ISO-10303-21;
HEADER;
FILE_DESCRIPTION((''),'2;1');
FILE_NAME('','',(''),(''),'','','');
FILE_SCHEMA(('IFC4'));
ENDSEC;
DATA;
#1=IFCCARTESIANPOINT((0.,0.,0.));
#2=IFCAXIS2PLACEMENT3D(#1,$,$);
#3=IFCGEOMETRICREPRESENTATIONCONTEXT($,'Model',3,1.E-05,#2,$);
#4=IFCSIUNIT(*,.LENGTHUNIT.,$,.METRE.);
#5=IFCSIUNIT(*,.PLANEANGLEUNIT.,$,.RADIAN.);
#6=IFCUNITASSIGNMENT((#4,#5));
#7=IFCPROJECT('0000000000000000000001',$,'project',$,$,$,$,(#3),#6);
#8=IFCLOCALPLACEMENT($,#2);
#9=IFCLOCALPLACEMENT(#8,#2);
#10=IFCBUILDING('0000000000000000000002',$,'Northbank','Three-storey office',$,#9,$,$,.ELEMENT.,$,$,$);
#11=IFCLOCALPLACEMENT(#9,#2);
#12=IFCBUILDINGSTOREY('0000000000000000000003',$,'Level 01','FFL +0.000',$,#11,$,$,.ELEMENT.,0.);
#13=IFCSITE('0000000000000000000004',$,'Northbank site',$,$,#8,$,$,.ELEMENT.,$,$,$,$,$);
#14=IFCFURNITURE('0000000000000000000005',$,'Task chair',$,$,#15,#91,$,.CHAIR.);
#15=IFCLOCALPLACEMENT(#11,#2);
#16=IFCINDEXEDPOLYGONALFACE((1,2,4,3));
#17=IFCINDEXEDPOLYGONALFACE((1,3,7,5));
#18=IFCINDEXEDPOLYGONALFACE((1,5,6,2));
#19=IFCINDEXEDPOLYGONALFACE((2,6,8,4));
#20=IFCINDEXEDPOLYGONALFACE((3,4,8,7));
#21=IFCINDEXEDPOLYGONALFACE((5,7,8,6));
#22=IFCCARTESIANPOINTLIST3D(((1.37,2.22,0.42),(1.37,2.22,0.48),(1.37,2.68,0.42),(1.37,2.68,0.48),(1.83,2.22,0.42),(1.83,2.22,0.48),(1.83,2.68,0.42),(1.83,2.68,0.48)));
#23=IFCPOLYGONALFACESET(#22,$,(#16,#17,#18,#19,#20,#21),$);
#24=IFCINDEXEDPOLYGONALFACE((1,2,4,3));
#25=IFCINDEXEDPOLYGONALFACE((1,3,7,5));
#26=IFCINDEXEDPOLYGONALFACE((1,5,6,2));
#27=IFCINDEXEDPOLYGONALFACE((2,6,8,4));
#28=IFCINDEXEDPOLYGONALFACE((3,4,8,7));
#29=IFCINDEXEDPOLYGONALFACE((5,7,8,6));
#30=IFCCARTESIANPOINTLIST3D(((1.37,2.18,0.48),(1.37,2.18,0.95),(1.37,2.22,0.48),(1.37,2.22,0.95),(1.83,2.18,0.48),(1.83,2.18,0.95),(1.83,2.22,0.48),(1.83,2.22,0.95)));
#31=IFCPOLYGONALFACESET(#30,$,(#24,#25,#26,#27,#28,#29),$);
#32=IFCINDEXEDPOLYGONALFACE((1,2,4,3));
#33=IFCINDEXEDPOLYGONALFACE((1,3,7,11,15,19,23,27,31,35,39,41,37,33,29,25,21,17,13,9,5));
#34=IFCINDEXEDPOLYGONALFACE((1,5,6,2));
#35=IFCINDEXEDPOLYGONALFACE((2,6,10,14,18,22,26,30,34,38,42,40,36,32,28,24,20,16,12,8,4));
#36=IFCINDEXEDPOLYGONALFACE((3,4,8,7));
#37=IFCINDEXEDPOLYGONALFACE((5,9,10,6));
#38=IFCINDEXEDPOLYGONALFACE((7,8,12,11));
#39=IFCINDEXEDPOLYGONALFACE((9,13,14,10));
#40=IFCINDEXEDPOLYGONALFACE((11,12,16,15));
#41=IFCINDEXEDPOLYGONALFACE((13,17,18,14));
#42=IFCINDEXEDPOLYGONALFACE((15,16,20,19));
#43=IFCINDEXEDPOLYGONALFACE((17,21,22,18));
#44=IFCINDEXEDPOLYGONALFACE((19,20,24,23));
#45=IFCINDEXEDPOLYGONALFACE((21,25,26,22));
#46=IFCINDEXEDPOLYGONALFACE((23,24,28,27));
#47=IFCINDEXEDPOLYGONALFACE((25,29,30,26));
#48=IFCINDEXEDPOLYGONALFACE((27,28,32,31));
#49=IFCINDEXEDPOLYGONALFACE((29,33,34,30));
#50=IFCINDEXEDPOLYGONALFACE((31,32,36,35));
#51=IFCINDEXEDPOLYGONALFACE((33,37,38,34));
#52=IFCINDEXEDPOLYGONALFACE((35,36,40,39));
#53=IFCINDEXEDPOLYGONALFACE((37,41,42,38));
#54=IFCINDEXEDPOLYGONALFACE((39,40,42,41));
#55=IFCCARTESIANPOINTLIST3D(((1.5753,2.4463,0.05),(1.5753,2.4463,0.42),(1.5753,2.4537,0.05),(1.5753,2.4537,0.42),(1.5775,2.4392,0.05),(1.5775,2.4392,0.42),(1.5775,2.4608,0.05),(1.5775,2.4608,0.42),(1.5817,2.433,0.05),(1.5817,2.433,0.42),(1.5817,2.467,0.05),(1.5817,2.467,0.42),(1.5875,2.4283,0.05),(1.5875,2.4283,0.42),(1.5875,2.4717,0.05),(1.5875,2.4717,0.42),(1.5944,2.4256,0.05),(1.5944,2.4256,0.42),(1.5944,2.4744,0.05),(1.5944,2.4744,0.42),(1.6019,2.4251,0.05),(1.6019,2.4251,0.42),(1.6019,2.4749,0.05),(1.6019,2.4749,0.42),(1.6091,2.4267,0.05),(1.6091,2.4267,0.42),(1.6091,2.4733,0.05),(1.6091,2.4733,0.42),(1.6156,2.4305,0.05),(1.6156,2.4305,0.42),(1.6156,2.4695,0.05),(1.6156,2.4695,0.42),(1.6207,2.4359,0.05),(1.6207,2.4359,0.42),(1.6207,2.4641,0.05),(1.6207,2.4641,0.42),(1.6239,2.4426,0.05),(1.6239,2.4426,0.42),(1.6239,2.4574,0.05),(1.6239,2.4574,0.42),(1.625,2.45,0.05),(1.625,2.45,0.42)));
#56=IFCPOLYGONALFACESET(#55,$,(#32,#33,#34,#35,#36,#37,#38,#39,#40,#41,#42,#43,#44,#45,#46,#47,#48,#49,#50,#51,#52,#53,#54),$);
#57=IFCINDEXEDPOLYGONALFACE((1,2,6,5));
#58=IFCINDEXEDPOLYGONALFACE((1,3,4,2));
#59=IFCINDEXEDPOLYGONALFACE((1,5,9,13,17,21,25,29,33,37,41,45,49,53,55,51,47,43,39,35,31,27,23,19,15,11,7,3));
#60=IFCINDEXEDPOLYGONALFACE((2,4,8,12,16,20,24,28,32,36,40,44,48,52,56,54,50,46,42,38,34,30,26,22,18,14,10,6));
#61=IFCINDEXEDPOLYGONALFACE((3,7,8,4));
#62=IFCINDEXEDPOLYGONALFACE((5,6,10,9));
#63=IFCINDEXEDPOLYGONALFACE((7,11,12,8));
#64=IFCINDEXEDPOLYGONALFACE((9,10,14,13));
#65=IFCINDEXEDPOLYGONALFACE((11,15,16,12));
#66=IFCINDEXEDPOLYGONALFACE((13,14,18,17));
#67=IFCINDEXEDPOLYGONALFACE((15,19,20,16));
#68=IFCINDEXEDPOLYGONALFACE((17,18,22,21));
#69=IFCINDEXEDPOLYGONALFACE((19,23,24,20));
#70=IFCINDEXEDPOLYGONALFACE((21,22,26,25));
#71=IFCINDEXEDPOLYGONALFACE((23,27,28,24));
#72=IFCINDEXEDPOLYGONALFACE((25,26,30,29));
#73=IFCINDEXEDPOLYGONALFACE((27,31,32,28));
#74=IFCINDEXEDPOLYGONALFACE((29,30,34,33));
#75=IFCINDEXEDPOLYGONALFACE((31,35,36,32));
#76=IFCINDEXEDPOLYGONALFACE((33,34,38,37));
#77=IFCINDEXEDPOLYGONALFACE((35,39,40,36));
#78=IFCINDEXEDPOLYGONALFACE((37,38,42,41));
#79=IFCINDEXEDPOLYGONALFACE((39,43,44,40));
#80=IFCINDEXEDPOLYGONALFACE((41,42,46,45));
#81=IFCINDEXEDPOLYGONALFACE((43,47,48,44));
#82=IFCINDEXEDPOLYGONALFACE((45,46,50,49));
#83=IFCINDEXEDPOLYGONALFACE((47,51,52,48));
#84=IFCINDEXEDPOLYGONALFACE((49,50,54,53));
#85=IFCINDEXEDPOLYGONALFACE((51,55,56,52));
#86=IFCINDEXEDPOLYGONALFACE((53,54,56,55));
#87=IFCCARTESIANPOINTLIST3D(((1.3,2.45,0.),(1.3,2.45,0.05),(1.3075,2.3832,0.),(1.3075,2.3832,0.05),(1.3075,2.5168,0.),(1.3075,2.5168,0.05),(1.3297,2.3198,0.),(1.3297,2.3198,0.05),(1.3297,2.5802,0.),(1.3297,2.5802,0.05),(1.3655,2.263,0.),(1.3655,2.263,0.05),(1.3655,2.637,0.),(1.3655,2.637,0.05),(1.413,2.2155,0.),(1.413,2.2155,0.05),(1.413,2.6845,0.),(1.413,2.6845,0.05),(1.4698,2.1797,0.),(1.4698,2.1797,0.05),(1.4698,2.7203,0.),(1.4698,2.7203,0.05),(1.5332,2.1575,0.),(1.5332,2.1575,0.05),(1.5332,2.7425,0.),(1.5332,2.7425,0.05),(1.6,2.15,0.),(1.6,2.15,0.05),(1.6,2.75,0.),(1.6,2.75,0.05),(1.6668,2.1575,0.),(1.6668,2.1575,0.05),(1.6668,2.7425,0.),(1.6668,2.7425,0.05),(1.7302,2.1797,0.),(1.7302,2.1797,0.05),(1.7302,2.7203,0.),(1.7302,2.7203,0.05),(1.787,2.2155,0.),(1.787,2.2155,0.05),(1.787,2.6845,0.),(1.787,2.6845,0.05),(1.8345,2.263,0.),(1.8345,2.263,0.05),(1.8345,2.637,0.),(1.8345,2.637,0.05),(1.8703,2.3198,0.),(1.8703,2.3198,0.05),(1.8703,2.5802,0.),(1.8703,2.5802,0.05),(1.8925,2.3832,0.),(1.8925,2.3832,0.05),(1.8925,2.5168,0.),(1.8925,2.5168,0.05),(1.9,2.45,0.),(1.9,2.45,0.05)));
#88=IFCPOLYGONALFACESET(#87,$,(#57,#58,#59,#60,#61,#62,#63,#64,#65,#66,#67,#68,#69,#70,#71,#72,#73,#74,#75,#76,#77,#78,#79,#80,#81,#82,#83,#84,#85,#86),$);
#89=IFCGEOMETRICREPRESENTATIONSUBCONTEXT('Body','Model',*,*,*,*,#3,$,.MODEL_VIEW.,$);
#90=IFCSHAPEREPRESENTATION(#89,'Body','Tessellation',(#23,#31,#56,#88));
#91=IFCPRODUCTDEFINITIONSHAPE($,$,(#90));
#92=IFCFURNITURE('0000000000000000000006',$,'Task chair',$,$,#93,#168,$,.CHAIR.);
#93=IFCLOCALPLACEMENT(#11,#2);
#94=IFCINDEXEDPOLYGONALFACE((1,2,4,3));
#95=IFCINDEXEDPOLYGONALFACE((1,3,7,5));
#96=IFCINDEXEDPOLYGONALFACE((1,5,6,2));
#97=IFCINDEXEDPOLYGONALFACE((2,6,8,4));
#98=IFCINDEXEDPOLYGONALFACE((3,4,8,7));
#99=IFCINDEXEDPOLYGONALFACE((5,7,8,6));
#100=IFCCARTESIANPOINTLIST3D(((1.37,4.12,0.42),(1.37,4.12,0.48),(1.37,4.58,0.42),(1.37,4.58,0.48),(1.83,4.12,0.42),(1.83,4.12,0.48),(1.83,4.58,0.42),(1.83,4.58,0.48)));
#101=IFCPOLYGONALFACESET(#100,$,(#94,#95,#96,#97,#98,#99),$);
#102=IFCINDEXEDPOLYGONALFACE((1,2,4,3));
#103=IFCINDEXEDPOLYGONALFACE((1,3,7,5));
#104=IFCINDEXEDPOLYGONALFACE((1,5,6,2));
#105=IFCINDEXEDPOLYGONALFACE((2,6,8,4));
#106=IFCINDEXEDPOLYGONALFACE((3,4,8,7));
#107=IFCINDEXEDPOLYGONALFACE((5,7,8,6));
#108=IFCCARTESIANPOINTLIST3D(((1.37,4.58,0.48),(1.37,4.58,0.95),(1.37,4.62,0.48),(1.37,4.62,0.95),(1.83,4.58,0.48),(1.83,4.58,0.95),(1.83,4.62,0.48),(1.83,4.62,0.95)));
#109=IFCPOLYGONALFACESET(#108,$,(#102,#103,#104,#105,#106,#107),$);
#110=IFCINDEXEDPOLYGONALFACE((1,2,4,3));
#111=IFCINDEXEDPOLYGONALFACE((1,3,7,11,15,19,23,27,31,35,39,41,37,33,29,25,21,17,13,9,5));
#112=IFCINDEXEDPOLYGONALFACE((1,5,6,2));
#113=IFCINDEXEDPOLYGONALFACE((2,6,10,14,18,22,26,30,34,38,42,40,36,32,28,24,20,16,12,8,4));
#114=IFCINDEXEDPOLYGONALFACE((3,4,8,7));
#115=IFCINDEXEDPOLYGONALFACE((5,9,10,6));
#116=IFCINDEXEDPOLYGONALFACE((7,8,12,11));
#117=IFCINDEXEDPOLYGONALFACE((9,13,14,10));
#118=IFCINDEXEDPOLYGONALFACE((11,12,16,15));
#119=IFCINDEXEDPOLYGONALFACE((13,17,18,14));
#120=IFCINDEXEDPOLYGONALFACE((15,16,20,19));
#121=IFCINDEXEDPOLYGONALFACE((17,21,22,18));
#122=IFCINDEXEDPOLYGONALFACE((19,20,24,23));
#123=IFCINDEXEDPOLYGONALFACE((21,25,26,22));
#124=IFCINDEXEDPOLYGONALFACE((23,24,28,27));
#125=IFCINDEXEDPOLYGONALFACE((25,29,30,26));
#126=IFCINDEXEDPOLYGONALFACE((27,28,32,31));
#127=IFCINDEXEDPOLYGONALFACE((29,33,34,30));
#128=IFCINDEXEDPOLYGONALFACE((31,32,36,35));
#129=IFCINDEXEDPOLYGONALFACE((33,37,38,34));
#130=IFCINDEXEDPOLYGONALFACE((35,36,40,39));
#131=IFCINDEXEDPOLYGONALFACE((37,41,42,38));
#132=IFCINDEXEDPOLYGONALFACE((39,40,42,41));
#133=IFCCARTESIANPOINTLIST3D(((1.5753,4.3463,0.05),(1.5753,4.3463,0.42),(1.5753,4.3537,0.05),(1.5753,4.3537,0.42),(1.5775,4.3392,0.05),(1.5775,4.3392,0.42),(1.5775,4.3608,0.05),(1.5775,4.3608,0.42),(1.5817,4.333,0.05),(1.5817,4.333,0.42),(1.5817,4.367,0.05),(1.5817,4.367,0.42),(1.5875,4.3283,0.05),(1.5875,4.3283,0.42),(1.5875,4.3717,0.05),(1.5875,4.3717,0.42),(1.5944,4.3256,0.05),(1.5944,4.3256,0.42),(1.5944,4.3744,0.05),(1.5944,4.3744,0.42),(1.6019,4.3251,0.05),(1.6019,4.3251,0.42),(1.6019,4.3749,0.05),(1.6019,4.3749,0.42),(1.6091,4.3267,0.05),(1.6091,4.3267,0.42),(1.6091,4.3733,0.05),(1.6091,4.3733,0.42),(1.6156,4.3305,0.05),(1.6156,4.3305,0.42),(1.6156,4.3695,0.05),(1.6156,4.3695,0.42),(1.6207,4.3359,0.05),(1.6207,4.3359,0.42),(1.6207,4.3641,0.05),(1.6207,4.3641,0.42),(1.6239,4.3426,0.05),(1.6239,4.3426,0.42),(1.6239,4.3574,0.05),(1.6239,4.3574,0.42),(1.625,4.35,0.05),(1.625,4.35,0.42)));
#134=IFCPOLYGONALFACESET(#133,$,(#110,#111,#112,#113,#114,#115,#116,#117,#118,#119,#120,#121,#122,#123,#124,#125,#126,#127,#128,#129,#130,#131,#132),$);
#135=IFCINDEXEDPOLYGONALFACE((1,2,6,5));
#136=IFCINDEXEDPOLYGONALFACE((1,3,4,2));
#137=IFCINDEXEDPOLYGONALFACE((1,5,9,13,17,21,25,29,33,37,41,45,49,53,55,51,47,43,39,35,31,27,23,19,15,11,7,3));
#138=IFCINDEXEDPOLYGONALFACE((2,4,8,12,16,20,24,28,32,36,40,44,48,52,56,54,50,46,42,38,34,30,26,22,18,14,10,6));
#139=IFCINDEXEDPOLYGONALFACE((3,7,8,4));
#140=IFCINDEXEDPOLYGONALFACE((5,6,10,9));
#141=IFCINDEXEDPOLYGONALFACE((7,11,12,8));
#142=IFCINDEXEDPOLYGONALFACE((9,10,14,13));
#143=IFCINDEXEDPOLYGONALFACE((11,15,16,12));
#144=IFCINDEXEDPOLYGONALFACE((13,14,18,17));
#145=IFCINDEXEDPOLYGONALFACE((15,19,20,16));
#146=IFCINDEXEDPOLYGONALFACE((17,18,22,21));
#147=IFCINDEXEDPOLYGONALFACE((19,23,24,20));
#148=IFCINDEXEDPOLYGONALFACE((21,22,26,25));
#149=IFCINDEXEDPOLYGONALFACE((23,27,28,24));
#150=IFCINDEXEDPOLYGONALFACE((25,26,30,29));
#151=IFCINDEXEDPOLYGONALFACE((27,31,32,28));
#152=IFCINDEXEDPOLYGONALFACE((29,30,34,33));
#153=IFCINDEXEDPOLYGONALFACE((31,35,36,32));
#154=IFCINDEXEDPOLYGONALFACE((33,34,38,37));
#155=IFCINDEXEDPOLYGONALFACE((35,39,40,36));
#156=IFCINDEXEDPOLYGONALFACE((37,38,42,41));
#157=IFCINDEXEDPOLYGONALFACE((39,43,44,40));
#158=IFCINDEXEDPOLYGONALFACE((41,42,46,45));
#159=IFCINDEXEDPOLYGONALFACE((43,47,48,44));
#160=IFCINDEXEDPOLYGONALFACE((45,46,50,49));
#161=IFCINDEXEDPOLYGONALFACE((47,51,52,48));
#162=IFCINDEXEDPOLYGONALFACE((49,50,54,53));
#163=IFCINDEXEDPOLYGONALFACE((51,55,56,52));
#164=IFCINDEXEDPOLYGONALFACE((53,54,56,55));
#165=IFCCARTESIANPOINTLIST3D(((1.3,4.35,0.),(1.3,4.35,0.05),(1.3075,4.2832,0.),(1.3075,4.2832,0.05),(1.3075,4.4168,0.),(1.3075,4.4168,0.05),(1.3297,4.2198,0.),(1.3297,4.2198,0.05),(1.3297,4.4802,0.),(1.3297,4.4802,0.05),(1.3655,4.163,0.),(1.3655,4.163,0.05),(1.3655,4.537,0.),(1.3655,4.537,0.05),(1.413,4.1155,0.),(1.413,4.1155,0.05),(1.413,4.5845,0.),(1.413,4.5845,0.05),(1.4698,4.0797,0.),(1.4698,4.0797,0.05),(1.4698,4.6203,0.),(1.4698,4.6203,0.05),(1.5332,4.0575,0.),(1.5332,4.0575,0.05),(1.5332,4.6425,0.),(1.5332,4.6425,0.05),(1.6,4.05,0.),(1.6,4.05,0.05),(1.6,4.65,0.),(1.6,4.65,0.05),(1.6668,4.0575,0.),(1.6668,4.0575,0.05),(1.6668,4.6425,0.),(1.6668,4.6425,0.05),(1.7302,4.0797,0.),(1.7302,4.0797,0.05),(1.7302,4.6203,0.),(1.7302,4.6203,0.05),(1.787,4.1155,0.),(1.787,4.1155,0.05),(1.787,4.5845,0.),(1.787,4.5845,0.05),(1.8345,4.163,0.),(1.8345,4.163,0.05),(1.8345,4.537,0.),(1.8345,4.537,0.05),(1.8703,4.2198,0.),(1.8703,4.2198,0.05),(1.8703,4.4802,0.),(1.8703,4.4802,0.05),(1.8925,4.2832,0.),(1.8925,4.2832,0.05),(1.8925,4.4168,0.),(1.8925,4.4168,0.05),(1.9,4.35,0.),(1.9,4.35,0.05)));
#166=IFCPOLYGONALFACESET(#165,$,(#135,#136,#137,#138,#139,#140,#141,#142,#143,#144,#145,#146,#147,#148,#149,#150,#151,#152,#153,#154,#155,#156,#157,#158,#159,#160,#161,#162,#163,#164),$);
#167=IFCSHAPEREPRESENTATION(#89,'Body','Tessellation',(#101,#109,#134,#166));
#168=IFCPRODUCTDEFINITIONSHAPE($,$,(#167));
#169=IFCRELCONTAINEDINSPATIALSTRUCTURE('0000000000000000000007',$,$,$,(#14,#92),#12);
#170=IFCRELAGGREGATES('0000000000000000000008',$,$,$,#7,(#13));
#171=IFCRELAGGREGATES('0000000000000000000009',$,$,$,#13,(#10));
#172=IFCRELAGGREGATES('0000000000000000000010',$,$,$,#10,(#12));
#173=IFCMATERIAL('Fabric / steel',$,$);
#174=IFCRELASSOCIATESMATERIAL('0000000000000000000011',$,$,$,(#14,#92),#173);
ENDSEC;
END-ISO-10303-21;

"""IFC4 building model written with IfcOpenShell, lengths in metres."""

from ifc_helpers import new_model, si_unit, frame, origin, place, context, subcontext, project, spatial, rectangle, circle, extrude, material, element, save


model = new_model("IFC4")

# Units and contexts
model_context = context("Model", 3, precision=1e-05, world=origin())
body_context = subcontext(model_context, "Body", "Model", "MODEL_VIEW")
ifc_project = project(units=[si_unit("LENGTHUNIT", "METRE"), si_unit("PLANEANGLEUNIT", "RADIAN")], contexts=[model_context])

# Site, building, storey
site_placement = place(None, origin())
site = spatial("IfcSite", under=ifc_project, at=site_placement, Name="Northbank site", CompositionType="ELEMENT")
building_placement = place(site_placement, origin())
building = spatial("IfcBuilding", under=site, at=building_placement, Name="Northbank", Description="Three-storey office", CompositionType="ELEMENT")
storey_placement = place(building_placement, origin())
storey = spatial("IfcBuildingStorey", under=building, at=storey_placement, Name="Level 01", Description="FFL +0.000", CompositionType="ELEMENT", Elevation=0.0)

# Furniture
ifc_material_1 = material(Name="Fabric / steel")
furniture_1_placement = place(storey_placement, origin())
element("IfcFurniture", 1, at=furniture_1_placement, inside=storey, material=ifc_material_1, Name="Task chair", PredefinedType="CHAIR", context=body_context, shape_type="SweptSolid", body=[
    extrude(rectangle(XDim=0.46, YDim=0.46), frame((1.6, 2.45, 0.42)), (0.0, 0.0, 1.0), 0.06),
    extrude(rectangle(XDim=0.46, YDim=0.04), frame((1.6, 2.2, 0.48)), (0.0, 0.0, 1.0), 0.47),
    extrude(circle(Radius=0.025), frame((1.6, 2.45, 0.05), z_axis=(0.0, 0.0, 1.0), x_axis=(1.0, 0.0, 0.0)), (0.0, 0.0, 1.0), 0.37),
    extrude(circle(Radius=0.3), frame((1.6, 2.45, 0.0), z_axis=(0.0, 0.0, 1.0), x_axis=(1.0, 0.0, 0.0)), (0.0, 0.0, 1.0), 0.05),
])
furniture_2_placement = place(storey_placement, origin())
element("IfcFurniture", 2, at=furniture_2_placement, inside=storey, material=ifc_material_1, Name="Task chair", PredefinedType="CHAIR", context=body_context, shape_type="SweptSolid", body=[
    extrude(rectangle(XDim=0.46, YDim=0.46), frame((1.6, 4.35, 0.42)), (0.0, 0.0, 1.0), 0.06),
    extrude(rectangle(XDim=0.46, YDim=0.04), frame((1.6, 4.6, 0.48)), (0.0, 0.0, 1.0), 0.47),
    extrude(circle(Radius=0.025), frame((1.6, 4.35, 0.05), z_axis=(0.0, 0.0, 1.0), x_axis=(1.0, 0.0, 0.0)), (0.0, 0.0, 1.0), 0.37),
    extrude(circle(Radius=0.3), frame((1.6, 4.35, 0.0), z_axis=(0.0, 0.0, 1.0), x_axis=(1.0, 0.0, 0.0)), (0.0, 0.0, 1.0), 0.05),
])

save(model, "model.ifc")
